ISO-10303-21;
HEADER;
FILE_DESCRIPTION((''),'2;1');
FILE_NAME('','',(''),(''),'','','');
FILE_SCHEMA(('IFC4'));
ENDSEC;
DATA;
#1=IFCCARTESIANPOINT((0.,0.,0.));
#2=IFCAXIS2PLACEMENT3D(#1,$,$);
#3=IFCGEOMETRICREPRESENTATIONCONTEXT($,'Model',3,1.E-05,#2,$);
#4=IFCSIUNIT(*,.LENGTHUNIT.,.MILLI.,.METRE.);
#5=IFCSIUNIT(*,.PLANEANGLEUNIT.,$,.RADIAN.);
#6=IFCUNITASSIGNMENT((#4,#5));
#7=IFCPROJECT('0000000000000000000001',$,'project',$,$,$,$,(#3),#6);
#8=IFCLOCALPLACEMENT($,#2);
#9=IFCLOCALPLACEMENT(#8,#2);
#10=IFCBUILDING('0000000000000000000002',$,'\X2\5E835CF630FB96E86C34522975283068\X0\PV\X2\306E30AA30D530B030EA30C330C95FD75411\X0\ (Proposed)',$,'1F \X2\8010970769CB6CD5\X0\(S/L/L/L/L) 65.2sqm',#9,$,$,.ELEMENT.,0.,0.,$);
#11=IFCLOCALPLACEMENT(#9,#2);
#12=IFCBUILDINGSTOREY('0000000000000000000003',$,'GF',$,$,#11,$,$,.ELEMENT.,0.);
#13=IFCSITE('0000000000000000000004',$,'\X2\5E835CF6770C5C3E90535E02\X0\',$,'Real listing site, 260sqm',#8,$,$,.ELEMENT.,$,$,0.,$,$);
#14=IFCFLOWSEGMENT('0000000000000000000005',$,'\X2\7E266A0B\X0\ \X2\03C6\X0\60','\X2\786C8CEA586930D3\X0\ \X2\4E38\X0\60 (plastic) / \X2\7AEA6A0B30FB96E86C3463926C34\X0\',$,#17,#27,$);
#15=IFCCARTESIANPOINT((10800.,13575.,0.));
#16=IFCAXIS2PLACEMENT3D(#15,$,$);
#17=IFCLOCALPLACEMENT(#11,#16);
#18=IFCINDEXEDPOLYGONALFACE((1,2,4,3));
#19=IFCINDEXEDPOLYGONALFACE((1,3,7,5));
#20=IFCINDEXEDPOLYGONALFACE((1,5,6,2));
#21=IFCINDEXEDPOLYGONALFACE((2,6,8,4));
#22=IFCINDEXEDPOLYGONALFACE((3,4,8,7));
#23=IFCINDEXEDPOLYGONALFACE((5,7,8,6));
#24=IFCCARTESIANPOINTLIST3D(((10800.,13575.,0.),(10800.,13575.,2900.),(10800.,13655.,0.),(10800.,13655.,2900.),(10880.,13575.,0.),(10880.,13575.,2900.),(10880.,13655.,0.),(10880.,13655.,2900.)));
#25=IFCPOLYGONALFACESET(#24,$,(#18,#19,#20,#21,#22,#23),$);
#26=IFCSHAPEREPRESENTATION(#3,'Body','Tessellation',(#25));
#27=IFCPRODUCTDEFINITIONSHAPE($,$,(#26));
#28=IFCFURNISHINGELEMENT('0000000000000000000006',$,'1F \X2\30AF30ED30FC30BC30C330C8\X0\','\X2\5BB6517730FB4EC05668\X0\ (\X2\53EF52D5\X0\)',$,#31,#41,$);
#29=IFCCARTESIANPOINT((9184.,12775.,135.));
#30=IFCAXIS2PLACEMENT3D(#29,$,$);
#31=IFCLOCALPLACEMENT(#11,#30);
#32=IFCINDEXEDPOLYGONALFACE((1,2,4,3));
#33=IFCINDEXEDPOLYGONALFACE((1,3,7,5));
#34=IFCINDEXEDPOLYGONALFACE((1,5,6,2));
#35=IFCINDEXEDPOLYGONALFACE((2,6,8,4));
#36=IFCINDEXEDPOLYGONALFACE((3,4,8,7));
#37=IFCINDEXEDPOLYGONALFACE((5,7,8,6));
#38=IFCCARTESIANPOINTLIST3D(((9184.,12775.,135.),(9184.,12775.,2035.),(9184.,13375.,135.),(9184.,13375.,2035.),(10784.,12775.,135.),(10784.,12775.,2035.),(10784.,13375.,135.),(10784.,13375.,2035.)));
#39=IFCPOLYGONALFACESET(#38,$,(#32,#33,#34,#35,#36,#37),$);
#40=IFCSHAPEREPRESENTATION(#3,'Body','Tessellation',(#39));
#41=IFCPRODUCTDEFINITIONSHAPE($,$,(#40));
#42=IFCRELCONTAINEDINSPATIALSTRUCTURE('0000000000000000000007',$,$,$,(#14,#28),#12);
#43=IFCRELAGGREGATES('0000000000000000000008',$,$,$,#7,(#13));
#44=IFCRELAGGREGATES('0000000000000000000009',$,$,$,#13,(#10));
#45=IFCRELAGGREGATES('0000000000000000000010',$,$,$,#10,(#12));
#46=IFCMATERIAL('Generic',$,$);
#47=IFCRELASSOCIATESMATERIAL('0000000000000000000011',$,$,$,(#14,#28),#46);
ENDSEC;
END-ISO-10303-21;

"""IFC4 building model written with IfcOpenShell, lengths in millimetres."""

from ifc_helpers import new_model, si_unit, frame, frame_2d, origin, place, context, project, spatial, rectangle, extrude, material, element, save


model = new_model("IFC4")

# Units and contexts
model_context = context("Model", 3, precision=1e-05, world=origin())
ifc_project = project(units=[si_unit("LENGTHUNIT", "METRE", prefix="MILLI"), si_unit("PLANEANGLEUNIT", "RADIAN")], contexts=[model_context])

# Site, building, storey
site_placement = place(None, origin())
site = spatial("IfcSite", under=ifc_project, at=site_placement, Name="広島県尾道市", ObjectType="Real listing site, 260sqm", CompositionType="ELEMENT", RefElevation=0.0)
building_placement = place(site_placement, origin())
building = spatial("IfcBuilding", under=site, at=building_placement, Name="広島・雨水利用とPVのオフグリッド志向 (Proposed)", ObjectType="1F 耐震構法(S/L/L/L/L) 65.2sqm", CompositionType="ELEMENT", ElevationOfRefHeight=0.0, ElevationOfTerrain=0.0)
storey_placement = place(building_placement, origin())
storey = spatial("IfcBuildingStorey", under=building, at=storey_placement, Name="GF", CompositionType="ELEMENT", Elevation=0.0)

# Shared definitions
ifc_material_1 = material(Name="Generic")

# Flow segment
flow_segment_placement = place(storey_placement, frame((10800.0, 13575.0, 0.0)))
element("IfcFlowSegment", 1, at=flow_segment_placement, inside=storey, material=ifc_material_1, Name="縦樋 φ60", Description="硬質塩ビ 丸60 (plastic) / 竪樋・雨水排水", context=model_context, shape_type="SweptSolid", body=[
    extrude(rectangle(XDim=80.0, YDim=80.0, at=frame_2d((40.0, 40.0))), frame((10800.0, 13575.0, 0.0)), (0.0, 0.0, 1.0), 2900.0),
])

# Furnishing element
furnishing_placement = place(storey_placement, frame((9184.0, 12775.0, 135.0)))
element("IfcFurnishingElement", 2, at=furnishing_placement, inside=storey, material=ifc_material_1, Name="1F クローゼット", Description="家具・什器 (可動)", context=model_context, shape_type="SweptSolid", body=[
    extrude(rectangle(XDim=1600.0, YDim=600.0, at=frame_2d((800.0, 300.0))), frame((9184.0, 12775.0, 135.0)), (0.0, 0.0, 1.0), 1900.0),
])

save(model, "model.ifc")
